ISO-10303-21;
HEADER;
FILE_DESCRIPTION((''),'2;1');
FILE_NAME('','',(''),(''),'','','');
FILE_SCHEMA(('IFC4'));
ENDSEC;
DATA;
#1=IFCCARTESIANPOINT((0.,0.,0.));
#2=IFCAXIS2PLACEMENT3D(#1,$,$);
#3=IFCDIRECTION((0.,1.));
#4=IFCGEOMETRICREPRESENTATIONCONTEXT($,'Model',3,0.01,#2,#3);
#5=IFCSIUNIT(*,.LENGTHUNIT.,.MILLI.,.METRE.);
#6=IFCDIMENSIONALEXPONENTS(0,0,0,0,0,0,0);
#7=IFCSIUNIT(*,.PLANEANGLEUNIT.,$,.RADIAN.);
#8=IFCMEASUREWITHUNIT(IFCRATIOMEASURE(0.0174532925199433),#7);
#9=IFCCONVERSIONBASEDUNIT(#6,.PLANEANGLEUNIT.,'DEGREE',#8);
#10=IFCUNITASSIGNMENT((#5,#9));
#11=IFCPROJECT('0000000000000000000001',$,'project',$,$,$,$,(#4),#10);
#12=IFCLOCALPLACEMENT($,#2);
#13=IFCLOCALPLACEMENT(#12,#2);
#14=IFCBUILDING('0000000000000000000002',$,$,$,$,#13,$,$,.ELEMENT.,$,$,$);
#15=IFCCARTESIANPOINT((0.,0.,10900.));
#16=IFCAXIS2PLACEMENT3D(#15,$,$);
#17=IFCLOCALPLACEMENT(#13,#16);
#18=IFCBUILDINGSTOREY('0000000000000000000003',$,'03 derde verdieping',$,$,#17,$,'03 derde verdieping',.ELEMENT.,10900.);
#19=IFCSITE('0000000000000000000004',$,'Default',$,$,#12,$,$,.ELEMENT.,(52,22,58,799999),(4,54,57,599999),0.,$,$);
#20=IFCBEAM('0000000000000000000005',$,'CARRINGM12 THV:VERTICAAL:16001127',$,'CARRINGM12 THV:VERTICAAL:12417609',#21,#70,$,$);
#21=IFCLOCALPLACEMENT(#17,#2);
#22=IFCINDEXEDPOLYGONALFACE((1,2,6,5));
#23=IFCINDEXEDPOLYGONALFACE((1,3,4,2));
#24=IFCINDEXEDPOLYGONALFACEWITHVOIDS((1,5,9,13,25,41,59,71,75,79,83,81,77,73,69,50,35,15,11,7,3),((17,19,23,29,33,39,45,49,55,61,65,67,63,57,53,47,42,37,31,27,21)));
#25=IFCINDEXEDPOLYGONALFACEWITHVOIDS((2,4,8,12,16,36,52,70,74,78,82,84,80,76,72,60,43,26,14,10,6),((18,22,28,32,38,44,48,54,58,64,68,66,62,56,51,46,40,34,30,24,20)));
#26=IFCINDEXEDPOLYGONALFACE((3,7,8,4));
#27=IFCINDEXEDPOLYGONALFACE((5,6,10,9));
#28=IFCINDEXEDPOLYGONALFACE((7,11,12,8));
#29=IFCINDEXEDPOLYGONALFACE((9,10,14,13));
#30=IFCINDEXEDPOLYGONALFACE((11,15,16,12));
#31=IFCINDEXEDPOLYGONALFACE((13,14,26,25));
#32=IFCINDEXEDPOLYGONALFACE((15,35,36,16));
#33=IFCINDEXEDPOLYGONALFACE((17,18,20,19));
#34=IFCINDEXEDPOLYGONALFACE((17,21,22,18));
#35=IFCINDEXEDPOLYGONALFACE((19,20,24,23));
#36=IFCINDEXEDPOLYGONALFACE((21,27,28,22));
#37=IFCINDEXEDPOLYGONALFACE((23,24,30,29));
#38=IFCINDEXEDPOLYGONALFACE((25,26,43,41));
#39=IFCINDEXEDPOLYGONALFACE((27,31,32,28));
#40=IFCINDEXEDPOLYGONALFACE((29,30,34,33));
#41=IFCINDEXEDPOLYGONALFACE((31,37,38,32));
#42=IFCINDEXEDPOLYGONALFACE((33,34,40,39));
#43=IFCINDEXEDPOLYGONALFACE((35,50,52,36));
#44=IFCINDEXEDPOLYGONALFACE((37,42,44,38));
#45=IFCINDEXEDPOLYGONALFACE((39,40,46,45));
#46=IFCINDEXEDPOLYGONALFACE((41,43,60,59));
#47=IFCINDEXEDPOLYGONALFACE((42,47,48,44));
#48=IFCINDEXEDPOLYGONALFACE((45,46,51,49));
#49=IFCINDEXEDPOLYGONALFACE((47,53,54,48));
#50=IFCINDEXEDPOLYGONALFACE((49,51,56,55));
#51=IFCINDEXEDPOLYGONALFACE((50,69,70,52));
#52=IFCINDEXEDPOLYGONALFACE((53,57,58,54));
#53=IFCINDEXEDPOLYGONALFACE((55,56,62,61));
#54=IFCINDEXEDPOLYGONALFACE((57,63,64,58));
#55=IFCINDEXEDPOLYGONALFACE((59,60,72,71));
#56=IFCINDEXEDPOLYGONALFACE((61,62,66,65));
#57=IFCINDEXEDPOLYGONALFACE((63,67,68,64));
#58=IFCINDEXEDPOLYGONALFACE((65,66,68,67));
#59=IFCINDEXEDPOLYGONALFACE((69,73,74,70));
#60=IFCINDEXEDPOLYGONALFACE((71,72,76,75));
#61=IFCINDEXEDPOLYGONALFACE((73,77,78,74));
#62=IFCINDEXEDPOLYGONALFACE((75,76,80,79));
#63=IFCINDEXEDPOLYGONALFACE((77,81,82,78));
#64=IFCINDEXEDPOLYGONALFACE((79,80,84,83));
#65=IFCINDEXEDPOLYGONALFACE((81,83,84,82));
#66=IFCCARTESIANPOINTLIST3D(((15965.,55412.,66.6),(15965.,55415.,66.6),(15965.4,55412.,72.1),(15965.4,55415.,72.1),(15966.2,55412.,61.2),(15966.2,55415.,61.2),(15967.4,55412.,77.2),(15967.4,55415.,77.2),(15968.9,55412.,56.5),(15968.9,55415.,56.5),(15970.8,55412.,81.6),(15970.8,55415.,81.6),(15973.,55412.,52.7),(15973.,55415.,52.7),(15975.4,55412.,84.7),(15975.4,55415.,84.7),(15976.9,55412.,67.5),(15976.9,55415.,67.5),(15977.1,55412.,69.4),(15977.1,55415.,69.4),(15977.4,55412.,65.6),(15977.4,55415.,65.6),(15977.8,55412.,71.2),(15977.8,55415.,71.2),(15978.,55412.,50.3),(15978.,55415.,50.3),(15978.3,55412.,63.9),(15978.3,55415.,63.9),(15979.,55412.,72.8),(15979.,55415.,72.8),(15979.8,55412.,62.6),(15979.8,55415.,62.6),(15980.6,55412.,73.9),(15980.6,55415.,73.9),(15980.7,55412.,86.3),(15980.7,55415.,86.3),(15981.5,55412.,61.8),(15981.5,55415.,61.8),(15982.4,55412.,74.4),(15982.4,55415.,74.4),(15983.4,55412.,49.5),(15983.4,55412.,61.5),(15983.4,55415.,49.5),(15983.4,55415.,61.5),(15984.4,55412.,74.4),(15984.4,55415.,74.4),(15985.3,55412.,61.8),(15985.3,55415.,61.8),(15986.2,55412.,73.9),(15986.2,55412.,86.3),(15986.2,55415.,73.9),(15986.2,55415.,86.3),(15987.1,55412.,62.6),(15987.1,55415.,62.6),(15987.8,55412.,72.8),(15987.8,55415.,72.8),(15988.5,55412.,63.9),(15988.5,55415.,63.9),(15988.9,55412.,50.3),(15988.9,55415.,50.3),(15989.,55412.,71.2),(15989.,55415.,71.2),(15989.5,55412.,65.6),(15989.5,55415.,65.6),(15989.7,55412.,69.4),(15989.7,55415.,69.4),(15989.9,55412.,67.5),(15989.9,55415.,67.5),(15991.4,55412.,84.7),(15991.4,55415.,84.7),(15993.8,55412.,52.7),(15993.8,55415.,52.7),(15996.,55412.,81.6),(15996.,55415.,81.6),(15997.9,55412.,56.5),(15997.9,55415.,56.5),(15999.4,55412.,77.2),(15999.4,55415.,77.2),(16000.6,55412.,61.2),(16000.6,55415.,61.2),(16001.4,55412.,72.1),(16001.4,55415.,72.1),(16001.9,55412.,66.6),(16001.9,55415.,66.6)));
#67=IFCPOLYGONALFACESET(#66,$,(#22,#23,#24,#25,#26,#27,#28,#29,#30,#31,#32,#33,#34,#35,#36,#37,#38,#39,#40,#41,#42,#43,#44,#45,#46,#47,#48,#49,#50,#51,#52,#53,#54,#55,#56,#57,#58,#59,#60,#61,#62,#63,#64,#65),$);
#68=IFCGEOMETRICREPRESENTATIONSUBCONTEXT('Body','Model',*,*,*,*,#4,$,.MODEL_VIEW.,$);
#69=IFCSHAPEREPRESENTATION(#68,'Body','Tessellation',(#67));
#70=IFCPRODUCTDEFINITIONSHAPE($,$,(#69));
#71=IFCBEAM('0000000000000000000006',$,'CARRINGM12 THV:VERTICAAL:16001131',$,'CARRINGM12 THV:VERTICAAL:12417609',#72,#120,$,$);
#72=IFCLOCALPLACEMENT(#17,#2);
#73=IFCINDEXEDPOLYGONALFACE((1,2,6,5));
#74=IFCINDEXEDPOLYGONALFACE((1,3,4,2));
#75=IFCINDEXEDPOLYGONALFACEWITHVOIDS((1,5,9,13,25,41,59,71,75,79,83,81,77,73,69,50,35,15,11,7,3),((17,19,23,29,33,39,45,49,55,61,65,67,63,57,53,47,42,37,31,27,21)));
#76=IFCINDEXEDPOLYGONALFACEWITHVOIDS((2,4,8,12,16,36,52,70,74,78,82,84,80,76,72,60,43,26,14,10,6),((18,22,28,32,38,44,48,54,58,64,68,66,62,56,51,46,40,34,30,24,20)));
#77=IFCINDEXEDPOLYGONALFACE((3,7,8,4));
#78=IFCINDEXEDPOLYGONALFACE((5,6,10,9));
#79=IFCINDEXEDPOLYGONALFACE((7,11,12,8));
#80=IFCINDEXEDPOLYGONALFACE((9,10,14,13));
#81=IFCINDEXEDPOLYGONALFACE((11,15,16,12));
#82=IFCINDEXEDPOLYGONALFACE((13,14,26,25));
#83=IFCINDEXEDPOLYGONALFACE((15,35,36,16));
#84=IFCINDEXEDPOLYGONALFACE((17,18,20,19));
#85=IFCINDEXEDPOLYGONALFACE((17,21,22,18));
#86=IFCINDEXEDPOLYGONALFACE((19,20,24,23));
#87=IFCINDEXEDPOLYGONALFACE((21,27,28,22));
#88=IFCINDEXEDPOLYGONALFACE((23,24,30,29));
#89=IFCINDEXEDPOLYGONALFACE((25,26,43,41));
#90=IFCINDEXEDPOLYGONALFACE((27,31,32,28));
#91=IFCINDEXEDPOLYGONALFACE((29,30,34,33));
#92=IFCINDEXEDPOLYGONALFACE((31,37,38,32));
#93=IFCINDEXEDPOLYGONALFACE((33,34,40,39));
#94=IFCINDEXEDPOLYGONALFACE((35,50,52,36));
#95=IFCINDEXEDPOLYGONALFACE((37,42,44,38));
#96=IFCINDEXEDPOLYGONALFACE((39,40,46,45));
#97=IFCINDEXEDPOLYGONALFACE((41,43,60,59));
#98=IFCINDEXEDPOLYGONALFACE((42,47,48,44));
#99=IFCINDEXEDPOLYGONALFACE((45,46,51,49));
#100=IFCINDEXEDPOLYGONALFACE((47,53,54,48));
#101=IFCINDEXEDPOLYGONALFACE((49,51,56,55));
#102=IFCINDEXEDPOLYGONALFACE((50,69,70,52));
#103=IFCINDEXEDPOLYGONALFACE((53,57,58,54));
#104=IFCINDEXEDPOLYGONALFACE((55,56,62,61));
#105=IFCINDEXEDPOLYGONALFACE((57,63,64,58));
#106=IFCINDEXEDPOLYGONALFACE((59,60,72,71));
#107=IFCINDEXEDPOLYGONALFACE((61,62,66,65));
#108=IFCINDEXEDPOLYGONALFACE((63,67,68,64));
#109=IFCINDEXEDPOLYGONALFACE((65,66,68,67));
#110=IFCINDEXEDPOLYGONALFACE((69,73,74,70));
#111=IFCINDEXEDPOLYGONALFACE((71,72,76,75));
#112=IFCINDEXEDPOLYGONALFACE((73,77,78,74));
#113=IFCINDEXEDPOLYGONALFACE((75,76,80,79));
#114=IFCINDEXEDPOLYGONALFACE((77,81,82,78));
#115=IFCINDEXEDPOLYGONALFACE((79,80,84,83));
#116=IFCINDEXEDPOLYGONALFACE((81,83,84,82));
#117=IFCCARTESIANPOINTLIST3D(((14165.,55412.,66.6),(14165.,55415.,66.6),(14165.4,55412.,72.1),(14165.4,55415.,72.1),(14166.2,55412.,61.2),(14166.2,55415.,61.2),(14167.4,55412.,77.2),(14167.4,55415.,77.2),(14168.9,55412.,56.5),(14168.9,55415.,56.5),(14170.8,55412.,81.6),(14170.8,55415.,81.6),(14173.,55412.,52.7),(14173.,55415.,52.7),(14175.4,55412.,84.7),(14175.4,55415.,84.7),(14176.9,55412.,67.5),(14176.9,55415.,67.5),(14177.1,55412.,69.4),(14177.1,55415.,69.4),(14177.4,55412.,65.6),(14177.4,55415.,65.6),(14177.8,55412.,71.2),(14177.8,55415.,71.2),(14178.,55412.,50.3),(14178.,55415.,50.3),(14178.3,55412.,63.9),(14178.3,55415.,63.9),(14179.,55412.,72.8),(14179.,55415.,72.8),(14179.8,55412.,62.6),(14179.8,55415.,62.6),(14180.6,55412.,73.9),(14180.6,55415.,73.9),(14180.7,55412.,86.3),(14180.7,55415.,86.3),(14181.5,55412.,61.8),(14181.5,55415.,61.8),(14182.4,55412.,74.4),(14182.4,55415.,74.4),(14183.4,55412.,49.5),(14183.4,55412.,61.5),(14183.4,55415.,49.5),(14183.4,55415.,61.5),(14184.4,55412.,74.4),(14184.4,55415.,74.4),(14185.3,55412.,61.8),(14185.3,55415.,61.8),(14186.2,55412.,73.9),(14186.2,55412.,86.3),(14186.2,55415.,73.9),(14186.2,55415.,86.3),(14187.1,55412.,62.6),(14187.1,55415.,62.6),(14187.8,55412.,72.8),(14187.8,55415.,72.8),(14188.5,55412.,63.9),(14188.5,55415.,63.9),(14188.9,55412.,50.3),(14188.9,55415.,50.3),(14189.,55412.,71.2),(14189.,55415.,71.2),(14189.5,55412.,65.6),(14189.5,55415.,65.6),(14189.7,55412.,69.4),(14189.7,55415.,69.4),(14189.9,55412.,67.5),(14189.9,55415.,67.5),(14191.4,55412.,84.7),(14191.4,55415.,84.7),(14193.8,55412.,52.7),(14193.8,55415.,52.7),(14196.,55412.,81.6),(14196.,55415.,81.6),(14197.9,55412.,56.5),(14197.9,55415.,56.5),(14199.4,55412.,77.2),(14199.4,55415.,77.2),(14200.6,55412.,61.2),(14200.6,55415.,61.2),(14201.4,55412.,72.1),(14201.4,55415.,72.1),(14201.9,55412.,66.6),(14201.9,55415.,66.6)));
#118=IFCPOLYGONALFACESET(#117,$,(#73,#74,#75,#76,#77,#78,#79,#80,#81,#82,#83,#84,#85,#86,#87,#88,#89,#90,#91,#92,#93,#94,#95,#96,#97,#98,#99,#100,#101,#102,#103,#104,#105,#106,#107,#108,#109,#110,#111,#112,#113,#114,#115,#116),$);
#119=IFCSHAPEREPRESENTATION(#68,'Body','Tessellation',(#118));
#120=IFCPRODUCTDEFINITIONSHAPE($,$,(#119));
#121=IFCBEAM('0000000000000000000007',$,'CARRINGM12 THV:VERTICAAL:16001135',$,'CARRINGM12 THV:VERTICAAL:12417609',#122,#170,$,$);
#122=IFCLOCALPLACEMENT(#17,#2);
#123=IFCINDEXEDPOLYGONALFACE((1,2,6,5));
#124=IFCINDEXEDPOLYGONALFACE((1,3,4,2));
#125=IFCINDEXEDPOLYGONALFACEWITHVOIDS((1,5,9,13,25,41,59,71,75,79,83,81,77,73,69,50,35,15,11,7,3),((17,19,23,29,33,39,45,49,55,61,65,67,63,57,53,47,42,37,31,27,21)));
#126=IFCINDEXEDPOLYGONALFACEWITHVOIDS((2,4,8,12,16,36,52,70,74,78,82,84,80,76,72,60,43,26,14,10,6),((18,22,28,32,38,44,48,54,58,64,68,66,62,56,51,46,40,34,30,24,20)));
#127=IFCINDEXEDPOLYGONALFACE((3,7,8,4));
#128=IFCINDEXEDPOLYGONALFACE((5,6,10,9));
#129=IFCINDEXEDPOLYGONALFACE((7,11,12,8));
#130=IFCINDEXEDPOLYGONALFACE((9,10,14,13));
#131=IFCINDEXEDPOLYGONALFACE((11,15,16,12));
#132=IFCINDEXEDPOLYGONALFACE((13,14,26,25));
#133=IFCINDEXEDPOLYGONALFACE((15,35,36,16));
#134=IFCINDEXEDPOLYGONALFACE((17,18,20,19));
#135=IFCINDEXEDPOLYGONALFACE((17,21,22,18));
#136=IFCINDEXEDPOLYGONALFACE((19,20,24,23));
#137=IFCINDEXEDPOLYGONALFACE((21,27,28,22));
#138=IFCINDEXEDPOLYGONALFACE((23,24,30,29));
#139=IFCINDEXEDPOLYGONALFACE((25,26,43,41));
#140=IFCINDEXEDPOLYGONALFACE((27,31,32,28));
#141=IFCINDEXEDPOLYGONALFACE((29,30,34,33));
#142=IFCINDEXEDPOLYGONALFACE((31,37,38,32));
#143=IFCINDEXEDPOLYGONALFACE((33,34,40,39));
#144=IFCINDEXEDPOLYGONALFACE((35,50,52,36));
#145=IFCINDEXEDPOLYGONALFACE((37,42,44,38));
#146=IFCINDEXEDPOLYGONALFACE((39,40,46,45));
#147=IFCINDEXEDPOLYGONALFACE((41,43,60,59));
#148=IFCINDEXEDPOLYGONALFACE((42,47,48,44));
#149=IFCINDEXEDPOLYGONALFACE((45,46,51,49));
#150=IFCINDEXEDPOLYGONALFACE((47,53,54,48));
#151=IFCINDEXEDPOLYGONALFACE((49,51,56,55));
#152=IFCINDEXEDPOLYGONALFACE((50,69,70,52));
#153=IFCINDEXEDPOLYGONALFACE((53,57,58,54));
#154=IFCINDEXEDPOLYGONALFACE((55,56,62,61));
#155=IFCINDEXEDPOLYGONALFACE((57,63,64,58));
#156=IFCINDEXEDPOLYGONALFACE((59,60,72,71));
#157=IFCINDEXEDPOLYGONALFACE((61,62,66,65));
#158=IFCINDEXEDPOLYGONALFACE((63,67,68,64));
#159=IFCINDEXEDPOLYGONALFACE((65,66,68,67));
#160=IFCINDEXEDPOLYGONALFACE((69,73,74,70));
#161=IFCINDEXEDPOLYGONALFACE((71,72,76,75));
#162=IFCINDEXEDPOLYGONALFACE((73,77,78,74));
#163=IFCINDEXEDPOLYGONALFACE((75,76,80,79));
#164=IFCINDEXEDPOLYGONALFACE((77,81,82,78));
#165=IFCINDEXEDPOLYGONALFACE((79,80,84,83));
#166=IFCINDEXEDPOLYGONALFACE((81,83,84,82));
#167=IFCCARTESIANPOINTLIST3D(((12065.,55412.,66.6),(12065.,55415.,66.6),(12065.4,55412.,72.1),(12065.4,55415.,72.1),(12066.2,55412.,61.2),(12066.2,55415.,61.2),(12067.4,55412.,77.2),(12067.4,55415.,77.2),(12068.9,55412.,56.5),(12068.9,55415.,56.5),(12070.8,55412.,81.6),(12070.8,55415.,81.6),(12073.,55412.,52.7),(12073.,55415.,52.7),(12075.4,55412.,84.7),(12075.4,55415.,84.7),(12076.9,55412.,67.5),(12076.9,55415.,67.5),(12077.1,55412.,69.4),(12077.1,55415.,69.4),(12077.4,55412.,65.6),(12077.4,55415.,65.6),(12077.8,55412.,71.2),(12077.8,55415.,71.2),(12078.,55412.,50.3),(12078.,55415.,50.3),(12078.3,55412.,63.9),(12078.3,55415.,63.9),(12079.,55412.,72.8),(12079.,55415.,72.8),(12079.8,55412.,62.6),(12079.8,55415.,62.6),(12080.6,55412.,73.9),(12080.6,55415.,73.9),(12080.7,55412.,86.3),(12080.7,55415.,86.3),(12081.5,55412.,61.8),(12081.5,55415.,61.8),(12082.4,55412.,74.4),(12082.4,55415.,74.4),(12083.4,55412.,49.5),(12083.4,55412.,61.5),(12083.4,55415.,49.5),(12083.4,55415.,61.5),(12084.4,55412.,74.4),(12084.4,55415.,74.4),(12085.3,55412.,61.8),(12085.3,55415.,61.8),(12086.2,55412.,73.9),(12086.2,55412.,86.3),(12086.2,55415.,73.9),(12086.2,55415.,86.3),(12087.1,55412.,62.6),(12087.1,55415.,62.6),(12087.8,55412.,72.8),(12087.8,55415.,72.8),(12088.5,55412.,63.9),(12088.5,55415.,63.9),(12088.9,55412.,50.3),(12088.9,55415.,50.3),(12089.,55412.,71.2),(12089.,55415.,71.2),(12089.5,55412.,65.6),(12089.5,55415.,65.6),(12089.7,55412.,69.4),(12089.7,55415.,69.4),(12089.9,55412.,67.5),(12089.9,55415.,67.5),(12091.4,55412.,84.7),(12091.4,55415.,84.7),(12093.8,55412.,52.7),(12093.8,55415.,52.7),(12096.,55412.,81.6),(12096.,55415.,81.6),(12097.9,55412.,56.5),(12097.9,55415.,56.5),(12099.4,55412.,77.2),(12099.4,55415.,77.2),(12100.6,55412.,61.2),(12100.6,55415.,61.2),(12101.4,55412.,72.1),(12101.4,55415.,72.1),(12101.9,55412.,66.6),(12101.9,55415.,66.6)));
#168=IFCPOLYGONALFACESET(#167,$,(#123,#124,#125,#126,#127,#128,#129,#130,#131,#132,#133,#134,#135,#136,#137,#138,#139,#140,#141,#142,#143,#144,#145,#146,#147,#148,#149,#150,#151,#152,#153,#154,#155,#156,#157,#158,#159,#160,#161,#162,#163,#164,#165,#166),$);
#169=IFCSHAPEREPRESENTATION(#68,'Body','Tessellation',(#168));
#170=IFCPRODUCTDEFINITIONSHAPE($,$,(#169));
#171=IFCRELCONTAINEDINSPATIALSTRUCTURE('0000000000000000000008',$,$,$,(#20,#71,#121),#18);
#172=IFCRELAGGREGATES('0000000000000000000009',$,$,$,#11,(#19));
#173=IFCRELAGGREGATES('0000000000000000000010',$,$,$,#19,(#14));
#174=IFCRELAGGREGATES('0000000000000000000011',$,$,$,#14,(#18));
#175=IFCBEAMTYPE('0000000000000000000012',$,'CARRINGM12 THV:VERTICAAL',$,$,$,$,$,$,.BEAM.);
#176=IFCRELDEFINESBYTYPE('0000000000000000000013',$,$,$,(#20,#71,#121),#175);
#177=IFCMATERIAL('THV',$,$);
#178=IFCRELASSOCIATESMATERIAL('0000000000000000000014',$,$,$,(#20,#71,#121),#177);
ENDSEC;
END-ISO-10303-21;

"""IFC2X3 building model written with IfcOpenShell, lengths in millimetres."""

from ifc_helpers import new_model, entity, si_unit, converted_unit, direction, frame, origin, origin_2d_with_axis, place, context, subcontext, project, spatial, hollow_circle, extrude, material, type_object, element, save


model = new_model("IFC2X3")

# Units and contexts
model_context = context("Model", 3, precision=0.01, world=origin(), true_north=direction((0.0, 1.0)))
body_context = subcontext(model_context, "Body", "Model", "MODEL_VIEW")
ifc_project = project(units=[si_unit("LENGTHUNIT", "METRE", prefix="MILLI"), converted_unit("PLANEANGLEUNIT", "DEGREE", entity("IfcRatioMeasure", 0.0174532925199433), si_unit("PLANEANGLEUNIT", "RADIAN"), dimensions=[0, 0, 0, 0, 0, 0, 0])], contexts=[model_context])

# Site, building, storey
site_placement = place(None, origin())
site = spatial("IfcSite", under=ifc_project, at=site_placement, Name="Default", CompositionType="ELEMENT", RefLatitude=(52, 22, 58, 799999), RefLongitude=(4, 54, 57, 599999), RefElevation=0.0)
building_placement = place(site_placement, origin())
building = spatial("IfcBuilding", under=site, at=building_placement, CompositionType="ELEMENT")
storey_placement = place(building_placement, frame((0.0, 0.0, 10900.0)))
storey = spatial("IfcBuildingStorey", under=building, at=storey_placement, Name="03 derde verdieping", LongName="03 derde verdieping", CompositionType="ELEMENT", Elevation=10900.0)

# Beams
ifc_material_1 = material(Name="THV")
beam_type_1 = type_object("IfcBeamType", Name="CARRINGM12 THV:VERTICAAL", PredefinedType="BEAM")
beam_1_placement = place(storey_placement, origin())
element("IfcBeam", 1, at=beam_1_placement, inside=storey, type_object=beam_type_1, material=ifc_material_1, Name="CARRINGM12 THV:VERTICAAL:16001127", ObjectType="CARRINGM12 THV:VERTICAAL:12417609", context=body_context, shape_type="SweptSolid", body=[
    extrude(hollow_circle(Radius=18.5, WallThickness=12.0, at=origin_2d_with_axis()), frame((15983.4, 55412.0, 68.0), z_axis=(0.0, 1.0, 0.0), x_axis=(0.0, 0.0, -1.0)), (0.0, 0.0, 1.0), 3.0),
])
beam_2_placement = place(storey_placement, origin())
element("IfcBeam", 2, at=beam_2_placement, inside=storey, type_object=beam_type_1, material=ifc_material_1, Name="CARRINGM12 THV:VERTICAAL:16001131", ObjectType="CARRINGM12 THV:VERTICAAL:12417609", context=body_context, shape_type="SweptSolid", body=[
    extrude(hollow_circle(Radius=18.5, WallThickness=12.0, at=origin_2d_with_axis()), frame((14183.4, 55412.0, 68.0), z_axis=(0.0, 1.0, 0.0), x_axis=(0.0, 0.0, -1.0)), (0.0, 0.0, 1.0), 3.0),
])
beam_3_placement = place(storey_placement, origin())
element("IfcBeam", 3, at=beam_3_placement, inside=storey, type_object=beam_type_1, material=ifc_material_1, Name="CARRINGM12 THV:VERTICAAL:16001135", ObjectType="CARRINGM12 THV:VERTICAAL:12417609", context=body_context, shape_type="SweptSolid", body=[
    extrude(hollow_circle(Radius=18.5, WallThickness=12.0, at=origin_2d_with_axis()), frame((12083.4, 55412.0, 68.0), z_axis=(0.0, 1.0, 0.0), x_axis=(0.0, 0.0, -1.0)), (0.0, 0.0, 1.0), 3.0),
])

save(model, "model.ifc")
